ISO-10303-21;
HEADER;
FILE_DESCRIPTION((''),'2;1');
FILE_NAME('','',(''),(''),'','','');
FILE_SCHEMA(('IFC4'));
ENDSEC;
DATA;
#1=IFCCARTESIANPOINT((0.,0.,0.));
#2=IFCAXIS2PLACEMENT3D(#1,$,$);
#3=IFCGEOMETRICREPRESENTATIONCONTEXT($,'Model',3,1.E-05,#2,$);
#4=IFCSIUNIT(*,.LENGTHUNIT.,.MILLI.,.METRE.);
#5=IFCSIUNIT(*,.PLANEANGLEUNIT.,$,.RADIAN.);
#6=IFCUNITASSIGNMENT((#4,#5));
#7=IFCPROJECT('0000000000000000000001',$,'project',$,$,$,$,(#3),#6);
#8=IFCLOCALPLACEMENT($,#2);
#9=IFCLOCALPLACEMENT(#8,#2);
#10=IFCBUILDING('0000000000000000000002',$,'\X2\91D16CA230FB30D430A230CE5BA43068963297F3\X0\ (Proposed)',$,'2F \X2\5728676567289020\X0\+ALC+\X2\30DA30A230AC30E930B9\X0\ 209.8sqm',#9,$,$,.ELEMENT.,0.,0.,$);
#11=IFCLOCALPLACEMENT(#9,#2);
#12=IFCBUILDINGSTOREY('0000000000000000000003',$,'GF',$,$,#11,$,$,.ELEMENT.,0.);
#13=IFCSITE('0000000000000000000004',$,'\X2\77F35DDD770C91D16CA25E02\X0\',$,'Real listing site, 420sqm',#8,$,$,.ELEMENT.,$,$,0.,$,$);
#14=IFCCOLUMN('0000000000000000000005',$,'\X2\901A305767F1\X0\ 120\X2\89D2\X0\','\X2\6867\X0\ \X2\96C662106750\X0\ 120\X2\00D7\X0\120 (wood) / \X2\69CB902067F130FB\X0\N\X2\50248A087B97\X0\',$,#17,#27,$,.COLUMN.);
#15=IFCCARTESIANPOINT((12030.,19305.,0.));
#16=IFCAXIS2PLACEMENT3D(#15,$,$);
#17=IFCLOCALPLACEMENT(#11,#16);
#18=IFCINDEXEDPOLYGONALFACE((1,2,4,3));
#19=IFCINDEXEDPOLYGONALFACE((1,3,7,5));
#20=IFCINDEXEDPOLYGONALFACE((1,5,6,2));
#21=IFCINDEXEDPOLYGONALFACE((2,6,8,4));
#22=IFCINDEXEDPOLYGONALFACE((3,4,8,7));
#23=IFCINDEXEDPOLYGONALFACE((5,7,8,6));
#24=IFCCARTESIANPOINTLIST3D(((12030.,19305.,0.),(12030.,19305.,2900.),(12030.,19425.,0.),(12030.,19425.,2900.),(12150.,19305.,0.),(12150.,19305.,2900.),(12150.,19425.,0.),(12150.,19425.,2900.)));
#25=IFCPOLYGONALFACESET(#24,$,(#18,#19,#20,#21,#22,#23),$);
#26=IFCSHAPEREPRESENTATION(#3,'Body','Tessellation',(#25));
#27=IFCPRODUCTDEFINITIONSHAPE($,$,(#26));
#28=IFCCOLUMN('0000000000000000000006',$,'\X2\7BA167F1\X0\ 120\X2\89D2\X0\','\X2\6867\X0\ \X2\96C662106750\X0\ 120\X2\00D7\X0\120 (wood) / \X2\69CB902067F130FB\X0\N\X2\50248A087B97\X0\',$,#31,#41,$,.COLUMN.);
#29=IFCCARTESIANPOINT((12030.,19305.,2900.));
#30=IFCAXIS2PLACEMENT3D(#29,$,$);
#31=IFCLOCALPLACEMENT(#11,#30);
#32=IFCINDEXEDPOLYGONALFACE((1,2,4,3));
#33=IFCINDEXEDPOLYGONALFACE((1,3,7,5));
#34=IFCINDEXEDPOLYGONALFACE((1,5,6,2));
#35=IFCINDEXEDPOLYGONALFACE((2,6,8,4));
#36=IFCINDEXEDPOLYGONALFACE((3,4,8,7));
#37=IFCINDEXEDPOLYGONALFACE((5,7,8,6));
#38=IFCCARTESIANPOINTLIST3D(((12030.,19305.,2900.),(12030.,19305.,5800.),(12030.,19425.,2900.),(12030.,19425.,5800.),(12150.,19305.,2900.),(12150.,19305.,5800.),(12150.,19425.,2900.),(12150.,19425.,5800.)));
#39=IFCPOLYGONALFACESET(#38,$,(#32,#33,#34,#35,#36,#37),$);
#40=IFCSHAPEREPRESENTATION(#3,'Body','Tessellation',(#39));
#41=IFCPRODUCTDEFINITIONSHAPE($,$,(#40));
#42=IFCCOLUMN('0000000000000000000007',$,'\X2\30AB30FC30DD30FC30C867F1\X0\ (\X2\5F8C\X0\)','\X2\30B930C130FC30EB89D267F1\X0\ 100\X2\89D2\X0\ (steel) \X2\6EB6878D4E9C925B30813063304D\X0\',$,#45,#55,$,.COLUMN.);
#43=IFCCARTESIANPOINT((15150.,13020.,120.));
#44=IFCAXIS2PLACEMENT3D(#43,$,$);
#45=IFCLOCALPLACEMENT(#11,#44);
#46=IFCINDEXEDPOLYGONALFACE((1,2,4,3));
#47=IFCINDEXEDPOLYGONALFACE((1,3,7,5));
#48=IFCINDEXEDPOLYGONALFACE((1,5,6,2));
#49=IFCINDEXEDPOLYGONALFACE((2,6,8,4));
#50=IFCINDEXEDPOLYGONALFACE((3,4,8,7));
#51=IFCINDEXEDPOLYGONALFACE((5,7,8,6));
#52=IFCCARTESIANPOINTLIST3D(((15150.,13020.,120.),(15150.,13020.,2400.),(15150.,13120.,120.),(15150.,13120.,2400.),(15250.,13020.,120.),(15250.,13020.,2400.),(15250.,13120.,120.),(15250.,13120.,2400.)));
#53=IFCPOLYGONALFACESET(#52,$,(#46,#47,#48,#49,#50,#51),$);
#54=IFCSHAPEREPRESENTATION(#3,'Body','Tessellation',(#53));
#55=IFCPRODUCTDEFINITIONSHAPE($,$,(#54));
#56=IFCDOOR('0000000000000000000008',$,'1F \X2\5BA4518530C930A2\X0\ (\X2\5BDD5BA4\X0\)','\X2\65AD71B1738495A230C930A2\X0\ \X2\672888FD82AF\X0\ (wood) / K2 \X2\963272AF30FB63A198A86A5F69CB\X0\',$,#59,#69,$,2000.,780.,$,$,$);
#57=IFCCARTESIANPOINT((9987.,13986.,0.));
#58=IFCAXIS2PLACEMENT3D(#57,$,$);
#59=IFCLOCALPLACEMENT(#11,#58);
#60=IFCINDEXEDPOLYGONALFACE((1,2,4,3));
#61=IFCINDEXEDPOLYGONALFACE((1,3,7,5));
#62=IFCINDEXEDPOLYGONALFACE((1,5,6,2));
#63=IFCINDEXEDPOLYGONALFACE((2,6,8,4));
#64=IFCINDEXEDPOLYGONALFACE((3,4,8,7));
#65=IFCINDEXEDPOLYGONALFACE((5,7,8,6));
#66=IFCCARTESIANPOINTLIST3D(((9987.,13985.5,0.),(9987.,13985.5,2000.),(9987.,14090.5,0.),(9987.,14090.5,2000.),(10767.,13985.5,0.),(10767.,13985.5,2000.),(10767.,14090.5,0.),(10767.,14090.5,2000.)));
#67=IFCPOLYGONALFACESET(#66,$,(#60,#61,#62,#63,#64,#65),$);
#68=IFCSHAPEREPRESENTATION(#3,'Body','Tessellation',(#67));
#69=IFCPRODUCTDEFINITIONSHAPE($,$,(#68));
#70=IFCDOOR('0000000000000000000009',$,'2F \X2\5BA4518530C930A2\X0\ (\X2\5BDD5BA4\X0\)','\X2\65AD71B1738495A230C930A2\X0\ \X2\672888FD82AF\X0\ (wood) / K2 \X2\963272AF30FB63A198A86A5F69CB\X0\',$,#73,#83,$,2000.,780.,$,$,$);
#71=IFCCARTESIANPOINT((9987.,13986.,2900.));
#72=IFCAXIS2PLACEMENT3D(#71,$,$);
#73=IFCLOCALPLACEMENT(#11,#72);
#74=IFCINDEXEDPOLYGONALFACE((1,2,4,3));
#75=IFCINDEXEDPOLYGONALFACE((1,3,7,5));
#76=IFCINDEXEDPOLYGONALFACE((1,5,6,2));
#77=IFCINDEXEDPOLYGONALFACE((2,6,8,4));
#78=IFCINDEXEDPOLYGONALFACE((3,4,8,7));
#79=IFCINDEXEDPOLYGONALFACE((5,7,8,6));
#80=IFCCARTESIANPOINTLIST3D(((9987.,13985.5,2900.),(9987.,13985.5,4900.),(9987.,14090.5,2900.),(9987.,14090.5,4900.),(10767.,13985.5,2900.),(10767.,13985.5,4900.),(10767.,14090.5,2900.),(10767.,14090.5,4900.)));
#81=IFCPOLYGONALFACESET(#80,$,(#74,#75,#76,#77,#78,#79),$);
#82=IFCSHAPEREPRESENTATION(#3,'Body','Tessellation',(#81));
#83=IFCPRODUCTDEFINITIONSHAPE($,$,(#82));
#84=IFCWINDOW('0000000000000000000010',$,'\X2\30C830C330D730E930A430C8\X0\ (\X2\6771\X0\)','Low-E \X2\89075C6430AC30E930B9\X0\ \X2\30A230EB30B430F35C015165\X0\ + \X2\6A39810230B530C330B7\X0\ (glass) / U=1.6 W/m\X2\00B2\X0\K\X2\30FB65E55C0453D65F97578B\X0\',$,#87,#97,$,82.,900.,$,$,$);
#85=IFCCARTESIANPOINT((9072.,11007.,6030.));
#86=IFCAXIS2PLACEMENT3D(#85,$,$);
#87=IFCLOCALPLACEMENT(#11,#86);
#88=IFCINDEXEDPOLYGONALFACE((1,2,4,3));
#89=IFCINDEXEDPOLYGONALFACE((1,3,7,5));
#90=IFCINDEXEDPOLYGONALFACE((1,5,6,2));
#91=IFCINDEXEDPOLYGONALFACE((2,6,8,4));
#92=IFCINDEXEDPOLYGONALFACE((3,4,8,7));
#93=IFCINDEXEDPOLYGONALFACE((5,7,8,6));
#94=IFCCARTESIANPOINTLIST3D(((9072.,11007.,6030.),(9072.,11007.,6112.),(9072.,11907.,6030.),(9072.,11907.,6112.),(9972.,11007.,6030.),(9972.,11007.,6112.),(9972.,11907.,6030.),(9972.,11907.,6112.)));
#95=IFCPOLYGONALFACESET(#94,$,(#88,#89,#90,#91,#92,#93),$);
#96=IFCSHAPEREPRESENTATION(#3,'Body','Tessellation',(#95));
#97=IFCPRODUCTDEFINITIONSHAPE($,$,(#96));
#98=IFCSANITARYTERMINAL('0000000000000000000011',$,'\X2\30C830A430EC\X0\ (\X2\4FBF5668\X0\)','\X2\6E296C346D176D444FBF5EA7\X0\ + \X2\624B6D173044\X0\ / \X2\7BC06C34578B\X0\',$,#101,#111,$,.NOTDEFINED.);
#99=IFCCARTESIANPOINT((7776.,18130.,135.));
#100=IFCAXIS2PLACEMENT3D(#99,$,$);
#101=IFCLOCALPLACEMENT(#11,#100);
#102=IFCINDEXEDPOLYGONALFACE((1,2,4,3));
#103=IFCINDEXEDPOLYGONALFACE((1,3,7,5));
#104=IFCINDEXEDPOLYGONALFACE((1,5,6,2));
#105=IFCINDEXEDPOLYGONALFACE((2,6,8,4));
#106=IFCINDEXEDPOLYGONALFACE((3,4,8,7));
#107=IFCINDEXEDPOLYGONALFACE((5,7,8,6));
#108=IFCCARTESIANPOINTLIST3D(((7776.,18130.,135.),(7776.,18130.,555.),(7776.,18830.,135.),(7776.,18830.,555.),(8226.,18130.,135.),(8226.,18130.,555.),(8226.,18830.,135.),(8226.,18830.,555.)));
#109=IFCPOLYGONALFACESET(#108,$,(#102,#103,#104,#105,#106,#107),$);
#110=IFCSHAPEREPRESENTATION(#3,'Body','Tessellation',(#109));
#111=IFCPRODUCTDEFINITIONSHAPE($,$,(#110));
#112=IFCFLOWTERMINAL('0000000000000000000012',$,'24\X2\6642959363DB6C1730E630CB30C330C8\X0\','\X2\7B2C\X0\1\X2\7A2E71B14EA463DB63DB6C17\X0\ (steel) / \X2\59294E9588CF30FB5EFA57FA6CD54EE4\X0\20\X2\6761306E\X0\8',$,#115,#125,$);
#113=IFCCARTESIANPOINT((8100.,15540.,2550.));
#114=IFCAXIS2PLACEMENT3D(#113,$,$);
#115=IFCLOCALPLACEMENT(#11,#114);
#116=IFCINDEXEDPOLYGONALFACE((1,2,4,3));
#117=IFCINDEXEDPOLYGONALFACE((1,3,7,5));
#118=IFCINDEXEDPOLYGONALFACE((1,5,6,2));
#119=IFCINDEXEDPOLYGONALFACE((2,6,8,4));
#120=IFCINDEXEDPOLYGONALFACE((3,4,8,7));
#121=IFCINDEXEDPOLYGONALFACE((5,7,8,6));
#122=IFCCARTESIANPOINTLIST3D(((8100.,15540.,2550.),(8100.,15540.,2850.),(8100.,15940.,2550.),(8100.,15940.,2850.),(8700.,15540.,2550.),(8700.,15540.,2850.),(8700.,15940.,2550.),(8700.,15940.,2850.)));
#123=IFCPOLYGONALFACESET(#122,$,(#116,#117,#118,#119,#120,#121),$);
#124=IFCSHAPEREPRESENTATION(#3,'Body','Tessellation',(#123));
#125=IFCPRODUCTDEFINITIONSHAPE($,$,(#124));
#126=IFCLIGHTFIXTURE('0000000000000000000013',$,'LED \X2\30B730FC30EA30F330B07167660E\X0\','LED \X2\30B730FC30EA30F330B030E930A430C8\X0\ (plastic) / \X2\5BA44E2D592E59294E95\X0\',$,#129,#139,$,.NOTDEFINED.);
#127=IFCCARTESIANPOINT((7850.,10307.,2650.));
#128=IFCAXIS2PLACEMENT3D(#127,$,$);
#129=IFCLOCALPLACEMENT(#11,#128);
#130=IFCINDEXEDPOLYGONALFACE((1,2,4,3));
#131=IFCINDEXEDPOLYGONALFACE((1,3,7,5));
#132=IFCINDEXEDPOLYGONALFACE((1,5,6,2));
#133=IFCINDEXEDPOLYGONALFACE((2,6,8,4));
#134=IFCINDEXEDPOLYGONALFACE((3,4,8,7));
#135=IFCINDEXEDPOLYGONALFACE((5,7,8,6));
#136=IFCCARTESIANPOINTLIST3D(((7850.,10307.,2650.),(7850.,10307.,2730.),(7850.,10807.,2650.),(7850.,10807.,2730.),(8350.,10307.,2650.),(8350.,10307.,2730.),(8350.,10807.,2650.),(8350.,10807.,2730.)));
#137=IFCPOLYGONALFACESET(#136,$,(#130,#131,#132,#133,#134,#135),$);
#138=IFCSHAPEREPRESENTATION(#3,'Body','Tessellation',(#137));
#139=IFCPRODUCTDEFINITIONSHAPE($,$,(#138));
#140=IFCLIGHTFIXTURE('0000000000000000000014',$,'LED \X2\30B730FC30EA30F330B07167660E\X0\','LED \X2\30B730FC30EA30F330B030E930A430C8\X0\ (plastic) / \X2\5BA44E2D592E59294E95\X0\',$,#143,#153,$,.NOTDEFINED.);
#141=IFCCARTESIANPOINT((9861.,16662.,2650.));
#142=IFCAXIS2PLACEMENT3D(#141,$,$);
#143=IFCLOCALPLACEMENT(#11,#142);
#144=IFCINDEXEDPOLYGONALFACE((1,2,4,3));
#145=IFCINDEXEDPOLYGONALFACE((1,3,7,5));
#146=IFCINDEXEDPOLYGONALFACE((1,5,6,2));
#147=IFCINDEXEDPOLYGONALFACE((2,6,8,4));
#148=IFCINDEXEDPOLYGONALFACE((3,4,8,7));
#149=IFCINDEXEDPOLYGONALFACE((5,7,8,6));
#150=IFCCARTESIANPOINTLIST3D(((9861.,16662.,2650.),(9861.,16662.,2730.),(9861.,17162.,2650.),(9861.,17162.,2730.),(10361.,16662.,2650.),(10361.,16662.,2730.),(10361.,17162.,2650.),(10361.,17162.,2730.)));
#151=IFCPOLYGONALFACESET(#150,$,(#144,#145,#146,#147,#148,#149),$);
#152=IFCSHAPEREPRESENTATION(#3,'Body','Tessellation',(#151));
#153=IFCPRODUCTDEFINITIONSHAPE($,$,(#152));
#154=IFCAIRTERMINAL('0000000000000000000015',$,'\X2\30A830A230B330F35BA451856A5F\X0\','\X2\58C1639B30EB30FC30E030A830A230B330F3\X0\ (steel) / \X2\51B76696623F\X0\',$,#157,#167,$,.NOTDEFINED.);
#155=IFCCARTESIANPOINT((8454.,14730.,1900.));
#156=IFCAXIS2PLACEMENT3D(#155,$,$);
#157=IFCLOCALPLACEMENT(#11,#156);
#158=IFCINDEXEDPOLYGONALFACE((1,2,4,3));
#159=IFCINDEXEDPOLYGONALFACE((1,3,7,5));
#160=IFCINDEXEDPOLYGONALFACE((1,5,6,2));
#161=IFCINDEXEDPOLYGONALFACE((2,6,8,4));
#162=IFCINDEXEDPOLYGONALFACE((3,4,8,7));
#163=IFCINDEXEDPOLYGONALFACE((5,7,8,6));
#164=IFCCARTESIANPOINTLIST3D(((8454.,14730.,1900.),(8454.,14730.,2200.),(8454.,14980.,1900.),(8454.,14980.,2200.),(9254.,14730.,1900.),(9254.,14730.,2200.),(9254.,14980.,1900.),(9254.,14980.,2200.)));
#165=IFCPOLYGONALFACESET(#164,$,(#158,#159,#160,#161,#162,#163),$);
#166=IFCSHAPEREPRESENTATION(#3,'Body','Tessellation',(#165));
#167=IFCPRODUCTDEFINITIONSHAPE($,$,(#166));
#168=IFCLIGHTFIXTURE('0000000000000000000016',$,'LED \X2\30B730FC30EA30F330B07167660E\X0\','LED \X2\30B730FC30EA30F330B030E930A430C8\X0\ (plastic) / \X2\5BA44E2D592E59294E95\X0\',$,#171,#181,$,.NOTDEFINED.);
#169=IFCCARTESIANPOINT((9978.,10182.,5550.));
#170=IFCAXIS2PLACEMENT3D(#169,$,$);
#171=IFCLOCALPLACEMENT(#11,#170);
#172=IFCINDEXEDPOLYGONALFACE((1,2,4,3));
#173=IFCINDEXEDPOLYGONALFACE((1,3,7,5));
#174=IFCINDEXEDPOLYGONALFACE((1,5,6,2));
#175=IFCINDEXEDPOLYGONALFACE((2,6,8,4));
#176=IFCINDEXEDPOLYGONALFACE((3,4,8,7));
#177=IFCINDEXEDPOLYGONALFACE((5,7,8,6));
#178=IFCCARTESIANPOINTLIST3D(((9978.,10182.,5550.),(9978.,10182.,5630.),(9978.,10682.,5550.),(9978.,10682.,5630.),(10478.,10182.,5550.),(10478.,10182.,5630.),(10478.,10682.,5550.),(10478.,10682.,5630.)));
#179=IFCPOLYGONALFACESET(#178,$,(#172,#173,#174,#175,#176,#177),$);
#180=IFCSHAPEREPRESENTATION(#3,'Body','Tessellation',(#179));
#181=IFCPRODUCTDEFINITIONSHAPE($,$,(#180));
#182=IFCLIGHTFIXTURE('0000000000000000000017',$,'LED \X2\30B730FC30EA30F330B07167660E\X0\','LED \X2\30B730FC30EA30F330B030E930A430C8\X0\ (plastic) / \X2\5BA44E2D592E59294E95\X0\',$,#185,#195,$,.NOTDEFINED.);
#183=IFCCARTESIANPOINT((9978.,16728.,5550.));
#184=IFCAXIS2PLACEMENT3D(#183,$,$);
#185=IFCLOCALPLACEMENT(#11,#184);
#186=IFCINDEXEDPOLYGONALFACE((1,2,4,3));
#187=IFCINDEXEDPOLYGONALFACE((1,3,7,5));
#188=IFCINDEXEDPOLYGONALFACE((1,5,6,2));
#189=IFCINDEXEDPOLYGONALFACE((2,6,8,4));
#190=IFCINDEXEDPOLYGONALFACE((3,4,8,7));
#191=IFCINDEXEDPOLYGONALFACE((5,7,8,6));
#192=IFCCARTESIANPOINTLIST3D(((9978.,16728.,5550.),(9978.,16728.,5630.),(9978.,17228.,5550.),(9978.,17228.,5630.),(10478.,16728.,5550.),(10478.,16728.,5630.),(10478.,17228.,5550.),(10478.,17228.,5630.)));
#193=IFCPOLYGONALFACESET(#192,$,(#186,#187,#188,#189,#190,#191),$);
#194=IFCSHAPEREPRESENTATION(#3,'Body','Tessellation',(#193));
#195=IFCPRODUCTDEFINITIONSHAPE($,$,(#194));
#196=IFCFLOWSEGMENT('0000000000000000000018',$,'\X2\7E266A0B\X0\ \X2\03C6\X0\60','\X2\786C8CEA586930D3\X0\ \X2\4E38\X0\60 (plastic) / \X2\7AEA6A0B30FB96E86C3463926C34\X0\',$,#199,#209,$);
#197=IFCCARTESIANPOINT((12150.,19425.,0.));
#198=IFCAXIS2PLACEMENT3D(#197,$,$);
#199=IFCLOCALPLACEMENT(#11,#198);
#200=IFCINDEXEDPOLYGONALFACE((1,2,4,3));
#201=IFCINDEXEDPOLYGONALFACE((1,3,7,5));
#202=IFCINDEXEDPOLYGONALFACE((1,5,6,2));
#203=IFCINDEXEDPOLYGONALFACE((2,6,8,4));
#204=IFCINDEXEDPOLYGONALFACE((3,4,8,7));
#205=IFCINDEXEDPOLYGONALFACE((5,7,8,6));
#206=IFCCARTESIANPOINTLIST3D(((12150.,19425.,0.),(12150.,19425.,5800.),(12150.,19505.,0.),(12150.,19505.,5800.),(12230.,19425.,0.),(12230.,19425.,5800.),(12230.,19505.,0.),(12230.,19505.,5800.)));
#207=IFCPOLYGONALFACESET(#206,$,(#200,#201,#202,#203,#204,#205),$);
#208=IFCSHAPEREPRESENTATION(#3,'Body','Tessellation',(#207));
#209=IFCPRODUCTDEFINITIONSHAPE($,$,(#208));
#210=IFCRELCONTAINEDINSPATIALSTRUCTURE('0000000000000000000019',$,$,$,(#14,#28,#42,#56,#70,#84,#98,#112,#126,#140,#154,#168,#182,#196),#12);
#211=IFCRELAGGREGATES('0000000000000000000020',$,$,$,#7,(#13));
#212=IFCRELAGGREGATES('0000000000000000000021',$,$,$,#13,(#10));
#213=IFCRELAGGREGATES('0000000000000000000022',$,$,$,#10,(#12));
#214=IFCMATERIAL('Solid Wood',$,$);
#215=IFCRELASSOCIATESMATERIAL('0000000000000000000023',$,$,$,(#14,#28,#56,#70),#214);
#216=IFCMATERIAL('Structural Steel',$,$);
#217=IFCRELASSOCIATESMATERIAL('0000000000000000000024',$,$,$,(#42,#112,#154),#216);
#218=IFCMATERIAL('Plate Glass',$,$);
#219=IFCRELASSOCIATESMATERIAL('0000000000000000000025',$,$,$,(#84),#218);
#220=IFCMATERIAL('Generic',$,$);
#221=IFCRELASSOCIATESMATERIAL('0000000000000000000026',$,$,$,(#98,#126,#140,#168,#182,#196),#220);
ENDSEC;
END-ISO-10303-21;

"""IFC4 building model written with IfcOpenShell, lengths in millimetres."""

from ifc_helpers import new_model, si_unit, frame, frame_2d, origin, place, context, project, spatial, rectangle, extrude, material, element, save


model = new_model("IFC4")

# Units and contexts
model_context = context("Model", 3, precision=1e-05, world=origin())
ifc_project = project(units=[si_unit("LENGTHUNIT", "METRE", prefix="MILLI"), si_unit("PLANEANGLEUNIT", "RADIAN")], contexts=[model_context])

# Site, building, storey
site_placement = place(None, origin())
site = spatial("IfcSite", under=ifc_project, at=site_placement, Name="石川県金沢市", ObjectType="Real listing site, 420sqm", CompositionType="ELEMENT", RefElevation=0.0)
building_placement = place(site_placement, origin())
building = spatial("IfcBuilding", under=site, at=building_placement, Name="金沢・ピアノ室と防音 (Proposed)", ObjectType="2F 在来木造+ALC+ペアガラス 209.8sqm", CompositionType="ELEMENT", ElevationOfRefHeight=0.0, ElevationOfTerrain=0.0)
storey_placement = place(building_placement, origin())
storey = spatial("IfcBuildingStorey", under=building, at=storey_placement, Name="GF", CompositionType="ELEMENT", Elevation=0.0)

# Columns
ifc_material_1 = material(Name="Solid Wood")
column_1_placement = place(storey_placement, frame((12030.0, 19305.0, 0.0)))
element("IfcColumn", 1, at=column_1_placement, inside=storey, material=ifc_material_1, Name="通し柱 120角", Description="桧 集成材 120×120 (wood) / 構造柱・N値計算", PredefinedType="COLUMN", context=model_context, shape_type="SweptSolid", body=[
    extrude(rectangle(XDim=120.0, YDim=120.0, at=frame_2d((60.0, 60.0))), frame((12030.0, 19305.0, 0.0)), (0.0, 0.0, 1.0), 2900.0),
])
column_2_placement = place(storey_placement, frame((12030.0, 19305.0, 2900.0)))
element("IfcColumn", 2, at=column_2_placement, inside=storey, material=ifc_material_1, Name="管柱 120角", Description="桧 集成材 120×120 (wood) / 構造柱・N値計算", PredefinedType="COLUMN", context=model_context, shape_type="SweptSolid", body=[
    extrude(rectangle(XDim=120.0, YDim=120.0, at=frame_2d((60.0, 60.0))), frame((12030.0, 19305.0, 2900.0)), (0.0, 0.0, 1.0), 2900.0),
])
ifc_material_2 = material(Name="Structural Steel")
column_3_placement = place(storey_placement, frame((15150.0, 13020.0, 120.0)))
element("IfcColumn", 3, at=column_3_placement, inside=storey, material=ifc_material_2, Name="カーポート柱 (後)", Description="スチール角柱 100角 (steel) 溶融亜鉛めっき", PredefinedType="COLUMN", context=model_context, shape_type="SweptSolid", body=[
    extrude(rectangle(XDim=100.0, YDim=100.0, at=frame_2d((50.0, 50.0))), frame((15150.0, 13020.0, 120.0)), (0.0, 0.0, 1.0), 2280.0),
])

# Door
door_1_placement = place(storey_placement, frame((9987.0, 13986.0, 0.0)))
element("IfcDoor", 4, at=door_1_placement, inside=storey, material=ifc_material_1, Name="1F 室内ドア (寝室)", Description="断熱玄関ドア 木製芯 (wood) / K2 防犯・採風機構", OverallHeight=2000.0, OverallWidth=780.0, context=model_context, shape_type="SweptSolid", body=[
    extrude(rectangle(XDim=780.0, YDim=105.0, at=frame_2d((390.0, 52.0))), frame((9987.0, 13986.0, 0.0)), (0.0, 0.0, 1.0), 2000.0),
])

# Door
door_2_placement = place(storey_placement, frame((9987.0, 13986.0, 2900.0)))
element("IfcDoor", 5, at=door_2_placement, inside=storey, material=ifc_material_1, Name="2F 室内ドア (寝室)", Description="断熱玄関ドア 木製芯 (wood) / K2 防犯・採風機構", OverallHeight=2000.0, OverallWidth=780.0, context=model_context, shape_type="SweptSolid", body=[
    extrude(rectangle(XDim=780.0, YDim=105.0, at=frame_2d((390.0, 52.0))), frame((9987.0, 13986.0, 2900.0)), (0.0, 0.0, 1.0), 2000.0),
])

# Window
ifc_material_3 = material(Name="Plate Glass")
window_placement = place(storey_placement, frame((9072.0, 11007.0, 6030.0)))
element("IfcWindow", 6, at=window_placement, inside=storey, material=ifc_material_3, Name="トップライト (東)", Description="Low-E 複層ガラス アルゴン封入 + 樹脂サッシ (glass) / U=1.6 W/m²K・日射取得型", OverallHeight=82.0, OverallWidth=900.0, context=model_context, shape_type="SweptSolid", body=[
    extrude(rectangle(XDim=900.0, YDim=900.0, at=frame_2d((450.0, 450.0))), frame((9072.0, 11007.0, 6030.0)), (0.0, 0.0, 1.0), 82.0),
])

# Sanitary terminal
ifc_material_4 = material(Name="Generic")
sanitary_terminal_placement = place(storey_placement, frame((7776.0, 18130.0, 135.0)))
element("IfcSanitaryTerminal", 7, at=sanitary_terminal_placement, inside=storey, material=ifc_material_4, Name="トイレ (便器)", Description="温水洗浄便座 + 手洗い / 節水型", PredefinedType="NOTDEFINED", context=model_context, shape_type="SweptSolid", body=[
    extrude(rectangle(XDim=450.0, YDim=700.0, at=frame_2d((225.0, 350.0))), frame((7776.0, 18130.0, 135.0)), (0.0, 0.0, 1.0), 420.0),
])

# Flow terminal
flow_terminal_placement = place(storey_placement, frame((8100.0, 15540.0, 2550.0)))
element("IfcFlowTerminal", 8, at=flow_terminal_placement, inside=storey, material=ifc_material_2, Name="24時間換気ユニット", Description="第1種熱交換換気 (steel) / 天井裏・建基法令20条の8", context=model_context, shape_type="SweptSolid", body=[
    extrude(rectangle(XDim=600.0, YDim=400.0, at=frame_2d((300.0, 200.0))), frame((8100.0, 15540.0, 2550.0)), (0.0, 0.0, 1.0), 300.0),
])

# Light fixtures
light_fixture_1_placement = place(storey_placement, frame((7850.0, 10307.0, 2650.0)))
element("IfcLightFixture", 9, at=light_fixture_1_placement, inside=storey, material=ifc_material_4, Name="LED シーリング照明", Description="LED シーリングライト (plastic) / 室中央天井", PredefinedType="NOTDEFINED", context=model_context, shape_type="SweptSolid", body=[
    extrude(rectangle(XDim=500.0, YDim=500.0, at=frame_2d((250.0, 250.0))), frame((7850.0, 10307.0, 2650.0)), (0.0, 0.0, 1.0), 80.0),
])
light_fixture_2_placement = place(storey_placement, frame((9861.0, 16662.0, 2650.0)))
element("IfcLightFixture", 10, at=light_fixture_2_placement, inside=storey, material=ifc_material_4, Name="LED シーリング照明", Description="LED シーリングライト (plastic) / 室中央天井", PredefinedType="NOTDEFINED", context=model_context, shape_type="SweptSolid", body=[
    extrude(rectangle(XDim=500.0, YDim=500.0, at=frame_2d((250.0, 250.0))), frame((9861.0, 16662.0, 2650.0)), (0.0, 0.0, 1.0), 80.0),
])

# Air terminal
air_terminal_placement = place(storey_placement, frame((8454.0, 14730.0, 1900.0)))
element("IfcAirTerminal", 11, at=air_terminal_placement, inside=storey, material=ifc_material_2, Name="エアコン室内機", Description="壁掛ルームエアコン (steel) / 冷暖房", PredefinedType="NOTDEFINED", context=model_context, shape_type="SweptSolid", body=[
    extrude(rectangle(XDim=800.0, YDim=250.0, at=frame_2d((400.0, 125.0))), frame((8454.0, 14730.0, 1900.0)), (0.0, 0.0, 1.0), 300.0),
])

# Light fixtures
light_fixture_3_placement = place(storey_placement, frame((9978.0, 10182.0, 5550.0)))
element("IfcLightFixture", 12, at=light_fixture_3_placement, inside=storey, material=ifc_material_4, Name="LED シーリング照明", Description="LED シーリングライト (plastic) / 室中央天井", PredefinedType="NOTDEFINED", context=model_context, shape_type="SweptSolid", body=[
    extrude(rectangle(XDim=500.0, YDim=500.0, at=frame_2d((250.0, 250.0))), frame((9978.0, 10182.0, 5550.0)), (0.0, 0.0, 1.0), 80.0),
])
light_fixture_4_placement = place(storey_placement, frame((9978.0, 16728.0, 5550.0)))
element("IfcLightFixture", 13, at=light_fixture_4_placement, inside=storey, material=ifc_material_4, Name="LED シーリング照明", Description="LED シーリングライト (plastic) / 室中央天井", PredefinedType="NOTDEFINED", context=model_context, shape_type="SweptSolid", body=[
    extrude(rectangle(XDim=500.0, YDim=500.0, at=frame_2d((250.0, 250.0))), frame((9978.0, 16728.0, 5550.0)), (0.0, 0.0, 1.0), 80.0),
])

# Flow segment
flow_segment_placement = place(storey_placement, frame((12150.0, 19425.0, 0.0)))
element("IfcFlowSegment", 14, at=flow_segment_placement, inside=storey, material=ifc_material_4, Name="縦樋 φ60", Description="硬質塩ビ 丸60 (plastic) / 竪樋・雨水排水", context=model_context, shape_type="SweptSolid", body=[
    extrude(rectangle(XDim=80.0, YDim=80.0, at=frame_2d((40.0, 40.0))), frame((12150.0, 19425.0, 0.0)), (0.0, 0.0, 1.0), 5800.0),
])

save(model, "model.ifc")
